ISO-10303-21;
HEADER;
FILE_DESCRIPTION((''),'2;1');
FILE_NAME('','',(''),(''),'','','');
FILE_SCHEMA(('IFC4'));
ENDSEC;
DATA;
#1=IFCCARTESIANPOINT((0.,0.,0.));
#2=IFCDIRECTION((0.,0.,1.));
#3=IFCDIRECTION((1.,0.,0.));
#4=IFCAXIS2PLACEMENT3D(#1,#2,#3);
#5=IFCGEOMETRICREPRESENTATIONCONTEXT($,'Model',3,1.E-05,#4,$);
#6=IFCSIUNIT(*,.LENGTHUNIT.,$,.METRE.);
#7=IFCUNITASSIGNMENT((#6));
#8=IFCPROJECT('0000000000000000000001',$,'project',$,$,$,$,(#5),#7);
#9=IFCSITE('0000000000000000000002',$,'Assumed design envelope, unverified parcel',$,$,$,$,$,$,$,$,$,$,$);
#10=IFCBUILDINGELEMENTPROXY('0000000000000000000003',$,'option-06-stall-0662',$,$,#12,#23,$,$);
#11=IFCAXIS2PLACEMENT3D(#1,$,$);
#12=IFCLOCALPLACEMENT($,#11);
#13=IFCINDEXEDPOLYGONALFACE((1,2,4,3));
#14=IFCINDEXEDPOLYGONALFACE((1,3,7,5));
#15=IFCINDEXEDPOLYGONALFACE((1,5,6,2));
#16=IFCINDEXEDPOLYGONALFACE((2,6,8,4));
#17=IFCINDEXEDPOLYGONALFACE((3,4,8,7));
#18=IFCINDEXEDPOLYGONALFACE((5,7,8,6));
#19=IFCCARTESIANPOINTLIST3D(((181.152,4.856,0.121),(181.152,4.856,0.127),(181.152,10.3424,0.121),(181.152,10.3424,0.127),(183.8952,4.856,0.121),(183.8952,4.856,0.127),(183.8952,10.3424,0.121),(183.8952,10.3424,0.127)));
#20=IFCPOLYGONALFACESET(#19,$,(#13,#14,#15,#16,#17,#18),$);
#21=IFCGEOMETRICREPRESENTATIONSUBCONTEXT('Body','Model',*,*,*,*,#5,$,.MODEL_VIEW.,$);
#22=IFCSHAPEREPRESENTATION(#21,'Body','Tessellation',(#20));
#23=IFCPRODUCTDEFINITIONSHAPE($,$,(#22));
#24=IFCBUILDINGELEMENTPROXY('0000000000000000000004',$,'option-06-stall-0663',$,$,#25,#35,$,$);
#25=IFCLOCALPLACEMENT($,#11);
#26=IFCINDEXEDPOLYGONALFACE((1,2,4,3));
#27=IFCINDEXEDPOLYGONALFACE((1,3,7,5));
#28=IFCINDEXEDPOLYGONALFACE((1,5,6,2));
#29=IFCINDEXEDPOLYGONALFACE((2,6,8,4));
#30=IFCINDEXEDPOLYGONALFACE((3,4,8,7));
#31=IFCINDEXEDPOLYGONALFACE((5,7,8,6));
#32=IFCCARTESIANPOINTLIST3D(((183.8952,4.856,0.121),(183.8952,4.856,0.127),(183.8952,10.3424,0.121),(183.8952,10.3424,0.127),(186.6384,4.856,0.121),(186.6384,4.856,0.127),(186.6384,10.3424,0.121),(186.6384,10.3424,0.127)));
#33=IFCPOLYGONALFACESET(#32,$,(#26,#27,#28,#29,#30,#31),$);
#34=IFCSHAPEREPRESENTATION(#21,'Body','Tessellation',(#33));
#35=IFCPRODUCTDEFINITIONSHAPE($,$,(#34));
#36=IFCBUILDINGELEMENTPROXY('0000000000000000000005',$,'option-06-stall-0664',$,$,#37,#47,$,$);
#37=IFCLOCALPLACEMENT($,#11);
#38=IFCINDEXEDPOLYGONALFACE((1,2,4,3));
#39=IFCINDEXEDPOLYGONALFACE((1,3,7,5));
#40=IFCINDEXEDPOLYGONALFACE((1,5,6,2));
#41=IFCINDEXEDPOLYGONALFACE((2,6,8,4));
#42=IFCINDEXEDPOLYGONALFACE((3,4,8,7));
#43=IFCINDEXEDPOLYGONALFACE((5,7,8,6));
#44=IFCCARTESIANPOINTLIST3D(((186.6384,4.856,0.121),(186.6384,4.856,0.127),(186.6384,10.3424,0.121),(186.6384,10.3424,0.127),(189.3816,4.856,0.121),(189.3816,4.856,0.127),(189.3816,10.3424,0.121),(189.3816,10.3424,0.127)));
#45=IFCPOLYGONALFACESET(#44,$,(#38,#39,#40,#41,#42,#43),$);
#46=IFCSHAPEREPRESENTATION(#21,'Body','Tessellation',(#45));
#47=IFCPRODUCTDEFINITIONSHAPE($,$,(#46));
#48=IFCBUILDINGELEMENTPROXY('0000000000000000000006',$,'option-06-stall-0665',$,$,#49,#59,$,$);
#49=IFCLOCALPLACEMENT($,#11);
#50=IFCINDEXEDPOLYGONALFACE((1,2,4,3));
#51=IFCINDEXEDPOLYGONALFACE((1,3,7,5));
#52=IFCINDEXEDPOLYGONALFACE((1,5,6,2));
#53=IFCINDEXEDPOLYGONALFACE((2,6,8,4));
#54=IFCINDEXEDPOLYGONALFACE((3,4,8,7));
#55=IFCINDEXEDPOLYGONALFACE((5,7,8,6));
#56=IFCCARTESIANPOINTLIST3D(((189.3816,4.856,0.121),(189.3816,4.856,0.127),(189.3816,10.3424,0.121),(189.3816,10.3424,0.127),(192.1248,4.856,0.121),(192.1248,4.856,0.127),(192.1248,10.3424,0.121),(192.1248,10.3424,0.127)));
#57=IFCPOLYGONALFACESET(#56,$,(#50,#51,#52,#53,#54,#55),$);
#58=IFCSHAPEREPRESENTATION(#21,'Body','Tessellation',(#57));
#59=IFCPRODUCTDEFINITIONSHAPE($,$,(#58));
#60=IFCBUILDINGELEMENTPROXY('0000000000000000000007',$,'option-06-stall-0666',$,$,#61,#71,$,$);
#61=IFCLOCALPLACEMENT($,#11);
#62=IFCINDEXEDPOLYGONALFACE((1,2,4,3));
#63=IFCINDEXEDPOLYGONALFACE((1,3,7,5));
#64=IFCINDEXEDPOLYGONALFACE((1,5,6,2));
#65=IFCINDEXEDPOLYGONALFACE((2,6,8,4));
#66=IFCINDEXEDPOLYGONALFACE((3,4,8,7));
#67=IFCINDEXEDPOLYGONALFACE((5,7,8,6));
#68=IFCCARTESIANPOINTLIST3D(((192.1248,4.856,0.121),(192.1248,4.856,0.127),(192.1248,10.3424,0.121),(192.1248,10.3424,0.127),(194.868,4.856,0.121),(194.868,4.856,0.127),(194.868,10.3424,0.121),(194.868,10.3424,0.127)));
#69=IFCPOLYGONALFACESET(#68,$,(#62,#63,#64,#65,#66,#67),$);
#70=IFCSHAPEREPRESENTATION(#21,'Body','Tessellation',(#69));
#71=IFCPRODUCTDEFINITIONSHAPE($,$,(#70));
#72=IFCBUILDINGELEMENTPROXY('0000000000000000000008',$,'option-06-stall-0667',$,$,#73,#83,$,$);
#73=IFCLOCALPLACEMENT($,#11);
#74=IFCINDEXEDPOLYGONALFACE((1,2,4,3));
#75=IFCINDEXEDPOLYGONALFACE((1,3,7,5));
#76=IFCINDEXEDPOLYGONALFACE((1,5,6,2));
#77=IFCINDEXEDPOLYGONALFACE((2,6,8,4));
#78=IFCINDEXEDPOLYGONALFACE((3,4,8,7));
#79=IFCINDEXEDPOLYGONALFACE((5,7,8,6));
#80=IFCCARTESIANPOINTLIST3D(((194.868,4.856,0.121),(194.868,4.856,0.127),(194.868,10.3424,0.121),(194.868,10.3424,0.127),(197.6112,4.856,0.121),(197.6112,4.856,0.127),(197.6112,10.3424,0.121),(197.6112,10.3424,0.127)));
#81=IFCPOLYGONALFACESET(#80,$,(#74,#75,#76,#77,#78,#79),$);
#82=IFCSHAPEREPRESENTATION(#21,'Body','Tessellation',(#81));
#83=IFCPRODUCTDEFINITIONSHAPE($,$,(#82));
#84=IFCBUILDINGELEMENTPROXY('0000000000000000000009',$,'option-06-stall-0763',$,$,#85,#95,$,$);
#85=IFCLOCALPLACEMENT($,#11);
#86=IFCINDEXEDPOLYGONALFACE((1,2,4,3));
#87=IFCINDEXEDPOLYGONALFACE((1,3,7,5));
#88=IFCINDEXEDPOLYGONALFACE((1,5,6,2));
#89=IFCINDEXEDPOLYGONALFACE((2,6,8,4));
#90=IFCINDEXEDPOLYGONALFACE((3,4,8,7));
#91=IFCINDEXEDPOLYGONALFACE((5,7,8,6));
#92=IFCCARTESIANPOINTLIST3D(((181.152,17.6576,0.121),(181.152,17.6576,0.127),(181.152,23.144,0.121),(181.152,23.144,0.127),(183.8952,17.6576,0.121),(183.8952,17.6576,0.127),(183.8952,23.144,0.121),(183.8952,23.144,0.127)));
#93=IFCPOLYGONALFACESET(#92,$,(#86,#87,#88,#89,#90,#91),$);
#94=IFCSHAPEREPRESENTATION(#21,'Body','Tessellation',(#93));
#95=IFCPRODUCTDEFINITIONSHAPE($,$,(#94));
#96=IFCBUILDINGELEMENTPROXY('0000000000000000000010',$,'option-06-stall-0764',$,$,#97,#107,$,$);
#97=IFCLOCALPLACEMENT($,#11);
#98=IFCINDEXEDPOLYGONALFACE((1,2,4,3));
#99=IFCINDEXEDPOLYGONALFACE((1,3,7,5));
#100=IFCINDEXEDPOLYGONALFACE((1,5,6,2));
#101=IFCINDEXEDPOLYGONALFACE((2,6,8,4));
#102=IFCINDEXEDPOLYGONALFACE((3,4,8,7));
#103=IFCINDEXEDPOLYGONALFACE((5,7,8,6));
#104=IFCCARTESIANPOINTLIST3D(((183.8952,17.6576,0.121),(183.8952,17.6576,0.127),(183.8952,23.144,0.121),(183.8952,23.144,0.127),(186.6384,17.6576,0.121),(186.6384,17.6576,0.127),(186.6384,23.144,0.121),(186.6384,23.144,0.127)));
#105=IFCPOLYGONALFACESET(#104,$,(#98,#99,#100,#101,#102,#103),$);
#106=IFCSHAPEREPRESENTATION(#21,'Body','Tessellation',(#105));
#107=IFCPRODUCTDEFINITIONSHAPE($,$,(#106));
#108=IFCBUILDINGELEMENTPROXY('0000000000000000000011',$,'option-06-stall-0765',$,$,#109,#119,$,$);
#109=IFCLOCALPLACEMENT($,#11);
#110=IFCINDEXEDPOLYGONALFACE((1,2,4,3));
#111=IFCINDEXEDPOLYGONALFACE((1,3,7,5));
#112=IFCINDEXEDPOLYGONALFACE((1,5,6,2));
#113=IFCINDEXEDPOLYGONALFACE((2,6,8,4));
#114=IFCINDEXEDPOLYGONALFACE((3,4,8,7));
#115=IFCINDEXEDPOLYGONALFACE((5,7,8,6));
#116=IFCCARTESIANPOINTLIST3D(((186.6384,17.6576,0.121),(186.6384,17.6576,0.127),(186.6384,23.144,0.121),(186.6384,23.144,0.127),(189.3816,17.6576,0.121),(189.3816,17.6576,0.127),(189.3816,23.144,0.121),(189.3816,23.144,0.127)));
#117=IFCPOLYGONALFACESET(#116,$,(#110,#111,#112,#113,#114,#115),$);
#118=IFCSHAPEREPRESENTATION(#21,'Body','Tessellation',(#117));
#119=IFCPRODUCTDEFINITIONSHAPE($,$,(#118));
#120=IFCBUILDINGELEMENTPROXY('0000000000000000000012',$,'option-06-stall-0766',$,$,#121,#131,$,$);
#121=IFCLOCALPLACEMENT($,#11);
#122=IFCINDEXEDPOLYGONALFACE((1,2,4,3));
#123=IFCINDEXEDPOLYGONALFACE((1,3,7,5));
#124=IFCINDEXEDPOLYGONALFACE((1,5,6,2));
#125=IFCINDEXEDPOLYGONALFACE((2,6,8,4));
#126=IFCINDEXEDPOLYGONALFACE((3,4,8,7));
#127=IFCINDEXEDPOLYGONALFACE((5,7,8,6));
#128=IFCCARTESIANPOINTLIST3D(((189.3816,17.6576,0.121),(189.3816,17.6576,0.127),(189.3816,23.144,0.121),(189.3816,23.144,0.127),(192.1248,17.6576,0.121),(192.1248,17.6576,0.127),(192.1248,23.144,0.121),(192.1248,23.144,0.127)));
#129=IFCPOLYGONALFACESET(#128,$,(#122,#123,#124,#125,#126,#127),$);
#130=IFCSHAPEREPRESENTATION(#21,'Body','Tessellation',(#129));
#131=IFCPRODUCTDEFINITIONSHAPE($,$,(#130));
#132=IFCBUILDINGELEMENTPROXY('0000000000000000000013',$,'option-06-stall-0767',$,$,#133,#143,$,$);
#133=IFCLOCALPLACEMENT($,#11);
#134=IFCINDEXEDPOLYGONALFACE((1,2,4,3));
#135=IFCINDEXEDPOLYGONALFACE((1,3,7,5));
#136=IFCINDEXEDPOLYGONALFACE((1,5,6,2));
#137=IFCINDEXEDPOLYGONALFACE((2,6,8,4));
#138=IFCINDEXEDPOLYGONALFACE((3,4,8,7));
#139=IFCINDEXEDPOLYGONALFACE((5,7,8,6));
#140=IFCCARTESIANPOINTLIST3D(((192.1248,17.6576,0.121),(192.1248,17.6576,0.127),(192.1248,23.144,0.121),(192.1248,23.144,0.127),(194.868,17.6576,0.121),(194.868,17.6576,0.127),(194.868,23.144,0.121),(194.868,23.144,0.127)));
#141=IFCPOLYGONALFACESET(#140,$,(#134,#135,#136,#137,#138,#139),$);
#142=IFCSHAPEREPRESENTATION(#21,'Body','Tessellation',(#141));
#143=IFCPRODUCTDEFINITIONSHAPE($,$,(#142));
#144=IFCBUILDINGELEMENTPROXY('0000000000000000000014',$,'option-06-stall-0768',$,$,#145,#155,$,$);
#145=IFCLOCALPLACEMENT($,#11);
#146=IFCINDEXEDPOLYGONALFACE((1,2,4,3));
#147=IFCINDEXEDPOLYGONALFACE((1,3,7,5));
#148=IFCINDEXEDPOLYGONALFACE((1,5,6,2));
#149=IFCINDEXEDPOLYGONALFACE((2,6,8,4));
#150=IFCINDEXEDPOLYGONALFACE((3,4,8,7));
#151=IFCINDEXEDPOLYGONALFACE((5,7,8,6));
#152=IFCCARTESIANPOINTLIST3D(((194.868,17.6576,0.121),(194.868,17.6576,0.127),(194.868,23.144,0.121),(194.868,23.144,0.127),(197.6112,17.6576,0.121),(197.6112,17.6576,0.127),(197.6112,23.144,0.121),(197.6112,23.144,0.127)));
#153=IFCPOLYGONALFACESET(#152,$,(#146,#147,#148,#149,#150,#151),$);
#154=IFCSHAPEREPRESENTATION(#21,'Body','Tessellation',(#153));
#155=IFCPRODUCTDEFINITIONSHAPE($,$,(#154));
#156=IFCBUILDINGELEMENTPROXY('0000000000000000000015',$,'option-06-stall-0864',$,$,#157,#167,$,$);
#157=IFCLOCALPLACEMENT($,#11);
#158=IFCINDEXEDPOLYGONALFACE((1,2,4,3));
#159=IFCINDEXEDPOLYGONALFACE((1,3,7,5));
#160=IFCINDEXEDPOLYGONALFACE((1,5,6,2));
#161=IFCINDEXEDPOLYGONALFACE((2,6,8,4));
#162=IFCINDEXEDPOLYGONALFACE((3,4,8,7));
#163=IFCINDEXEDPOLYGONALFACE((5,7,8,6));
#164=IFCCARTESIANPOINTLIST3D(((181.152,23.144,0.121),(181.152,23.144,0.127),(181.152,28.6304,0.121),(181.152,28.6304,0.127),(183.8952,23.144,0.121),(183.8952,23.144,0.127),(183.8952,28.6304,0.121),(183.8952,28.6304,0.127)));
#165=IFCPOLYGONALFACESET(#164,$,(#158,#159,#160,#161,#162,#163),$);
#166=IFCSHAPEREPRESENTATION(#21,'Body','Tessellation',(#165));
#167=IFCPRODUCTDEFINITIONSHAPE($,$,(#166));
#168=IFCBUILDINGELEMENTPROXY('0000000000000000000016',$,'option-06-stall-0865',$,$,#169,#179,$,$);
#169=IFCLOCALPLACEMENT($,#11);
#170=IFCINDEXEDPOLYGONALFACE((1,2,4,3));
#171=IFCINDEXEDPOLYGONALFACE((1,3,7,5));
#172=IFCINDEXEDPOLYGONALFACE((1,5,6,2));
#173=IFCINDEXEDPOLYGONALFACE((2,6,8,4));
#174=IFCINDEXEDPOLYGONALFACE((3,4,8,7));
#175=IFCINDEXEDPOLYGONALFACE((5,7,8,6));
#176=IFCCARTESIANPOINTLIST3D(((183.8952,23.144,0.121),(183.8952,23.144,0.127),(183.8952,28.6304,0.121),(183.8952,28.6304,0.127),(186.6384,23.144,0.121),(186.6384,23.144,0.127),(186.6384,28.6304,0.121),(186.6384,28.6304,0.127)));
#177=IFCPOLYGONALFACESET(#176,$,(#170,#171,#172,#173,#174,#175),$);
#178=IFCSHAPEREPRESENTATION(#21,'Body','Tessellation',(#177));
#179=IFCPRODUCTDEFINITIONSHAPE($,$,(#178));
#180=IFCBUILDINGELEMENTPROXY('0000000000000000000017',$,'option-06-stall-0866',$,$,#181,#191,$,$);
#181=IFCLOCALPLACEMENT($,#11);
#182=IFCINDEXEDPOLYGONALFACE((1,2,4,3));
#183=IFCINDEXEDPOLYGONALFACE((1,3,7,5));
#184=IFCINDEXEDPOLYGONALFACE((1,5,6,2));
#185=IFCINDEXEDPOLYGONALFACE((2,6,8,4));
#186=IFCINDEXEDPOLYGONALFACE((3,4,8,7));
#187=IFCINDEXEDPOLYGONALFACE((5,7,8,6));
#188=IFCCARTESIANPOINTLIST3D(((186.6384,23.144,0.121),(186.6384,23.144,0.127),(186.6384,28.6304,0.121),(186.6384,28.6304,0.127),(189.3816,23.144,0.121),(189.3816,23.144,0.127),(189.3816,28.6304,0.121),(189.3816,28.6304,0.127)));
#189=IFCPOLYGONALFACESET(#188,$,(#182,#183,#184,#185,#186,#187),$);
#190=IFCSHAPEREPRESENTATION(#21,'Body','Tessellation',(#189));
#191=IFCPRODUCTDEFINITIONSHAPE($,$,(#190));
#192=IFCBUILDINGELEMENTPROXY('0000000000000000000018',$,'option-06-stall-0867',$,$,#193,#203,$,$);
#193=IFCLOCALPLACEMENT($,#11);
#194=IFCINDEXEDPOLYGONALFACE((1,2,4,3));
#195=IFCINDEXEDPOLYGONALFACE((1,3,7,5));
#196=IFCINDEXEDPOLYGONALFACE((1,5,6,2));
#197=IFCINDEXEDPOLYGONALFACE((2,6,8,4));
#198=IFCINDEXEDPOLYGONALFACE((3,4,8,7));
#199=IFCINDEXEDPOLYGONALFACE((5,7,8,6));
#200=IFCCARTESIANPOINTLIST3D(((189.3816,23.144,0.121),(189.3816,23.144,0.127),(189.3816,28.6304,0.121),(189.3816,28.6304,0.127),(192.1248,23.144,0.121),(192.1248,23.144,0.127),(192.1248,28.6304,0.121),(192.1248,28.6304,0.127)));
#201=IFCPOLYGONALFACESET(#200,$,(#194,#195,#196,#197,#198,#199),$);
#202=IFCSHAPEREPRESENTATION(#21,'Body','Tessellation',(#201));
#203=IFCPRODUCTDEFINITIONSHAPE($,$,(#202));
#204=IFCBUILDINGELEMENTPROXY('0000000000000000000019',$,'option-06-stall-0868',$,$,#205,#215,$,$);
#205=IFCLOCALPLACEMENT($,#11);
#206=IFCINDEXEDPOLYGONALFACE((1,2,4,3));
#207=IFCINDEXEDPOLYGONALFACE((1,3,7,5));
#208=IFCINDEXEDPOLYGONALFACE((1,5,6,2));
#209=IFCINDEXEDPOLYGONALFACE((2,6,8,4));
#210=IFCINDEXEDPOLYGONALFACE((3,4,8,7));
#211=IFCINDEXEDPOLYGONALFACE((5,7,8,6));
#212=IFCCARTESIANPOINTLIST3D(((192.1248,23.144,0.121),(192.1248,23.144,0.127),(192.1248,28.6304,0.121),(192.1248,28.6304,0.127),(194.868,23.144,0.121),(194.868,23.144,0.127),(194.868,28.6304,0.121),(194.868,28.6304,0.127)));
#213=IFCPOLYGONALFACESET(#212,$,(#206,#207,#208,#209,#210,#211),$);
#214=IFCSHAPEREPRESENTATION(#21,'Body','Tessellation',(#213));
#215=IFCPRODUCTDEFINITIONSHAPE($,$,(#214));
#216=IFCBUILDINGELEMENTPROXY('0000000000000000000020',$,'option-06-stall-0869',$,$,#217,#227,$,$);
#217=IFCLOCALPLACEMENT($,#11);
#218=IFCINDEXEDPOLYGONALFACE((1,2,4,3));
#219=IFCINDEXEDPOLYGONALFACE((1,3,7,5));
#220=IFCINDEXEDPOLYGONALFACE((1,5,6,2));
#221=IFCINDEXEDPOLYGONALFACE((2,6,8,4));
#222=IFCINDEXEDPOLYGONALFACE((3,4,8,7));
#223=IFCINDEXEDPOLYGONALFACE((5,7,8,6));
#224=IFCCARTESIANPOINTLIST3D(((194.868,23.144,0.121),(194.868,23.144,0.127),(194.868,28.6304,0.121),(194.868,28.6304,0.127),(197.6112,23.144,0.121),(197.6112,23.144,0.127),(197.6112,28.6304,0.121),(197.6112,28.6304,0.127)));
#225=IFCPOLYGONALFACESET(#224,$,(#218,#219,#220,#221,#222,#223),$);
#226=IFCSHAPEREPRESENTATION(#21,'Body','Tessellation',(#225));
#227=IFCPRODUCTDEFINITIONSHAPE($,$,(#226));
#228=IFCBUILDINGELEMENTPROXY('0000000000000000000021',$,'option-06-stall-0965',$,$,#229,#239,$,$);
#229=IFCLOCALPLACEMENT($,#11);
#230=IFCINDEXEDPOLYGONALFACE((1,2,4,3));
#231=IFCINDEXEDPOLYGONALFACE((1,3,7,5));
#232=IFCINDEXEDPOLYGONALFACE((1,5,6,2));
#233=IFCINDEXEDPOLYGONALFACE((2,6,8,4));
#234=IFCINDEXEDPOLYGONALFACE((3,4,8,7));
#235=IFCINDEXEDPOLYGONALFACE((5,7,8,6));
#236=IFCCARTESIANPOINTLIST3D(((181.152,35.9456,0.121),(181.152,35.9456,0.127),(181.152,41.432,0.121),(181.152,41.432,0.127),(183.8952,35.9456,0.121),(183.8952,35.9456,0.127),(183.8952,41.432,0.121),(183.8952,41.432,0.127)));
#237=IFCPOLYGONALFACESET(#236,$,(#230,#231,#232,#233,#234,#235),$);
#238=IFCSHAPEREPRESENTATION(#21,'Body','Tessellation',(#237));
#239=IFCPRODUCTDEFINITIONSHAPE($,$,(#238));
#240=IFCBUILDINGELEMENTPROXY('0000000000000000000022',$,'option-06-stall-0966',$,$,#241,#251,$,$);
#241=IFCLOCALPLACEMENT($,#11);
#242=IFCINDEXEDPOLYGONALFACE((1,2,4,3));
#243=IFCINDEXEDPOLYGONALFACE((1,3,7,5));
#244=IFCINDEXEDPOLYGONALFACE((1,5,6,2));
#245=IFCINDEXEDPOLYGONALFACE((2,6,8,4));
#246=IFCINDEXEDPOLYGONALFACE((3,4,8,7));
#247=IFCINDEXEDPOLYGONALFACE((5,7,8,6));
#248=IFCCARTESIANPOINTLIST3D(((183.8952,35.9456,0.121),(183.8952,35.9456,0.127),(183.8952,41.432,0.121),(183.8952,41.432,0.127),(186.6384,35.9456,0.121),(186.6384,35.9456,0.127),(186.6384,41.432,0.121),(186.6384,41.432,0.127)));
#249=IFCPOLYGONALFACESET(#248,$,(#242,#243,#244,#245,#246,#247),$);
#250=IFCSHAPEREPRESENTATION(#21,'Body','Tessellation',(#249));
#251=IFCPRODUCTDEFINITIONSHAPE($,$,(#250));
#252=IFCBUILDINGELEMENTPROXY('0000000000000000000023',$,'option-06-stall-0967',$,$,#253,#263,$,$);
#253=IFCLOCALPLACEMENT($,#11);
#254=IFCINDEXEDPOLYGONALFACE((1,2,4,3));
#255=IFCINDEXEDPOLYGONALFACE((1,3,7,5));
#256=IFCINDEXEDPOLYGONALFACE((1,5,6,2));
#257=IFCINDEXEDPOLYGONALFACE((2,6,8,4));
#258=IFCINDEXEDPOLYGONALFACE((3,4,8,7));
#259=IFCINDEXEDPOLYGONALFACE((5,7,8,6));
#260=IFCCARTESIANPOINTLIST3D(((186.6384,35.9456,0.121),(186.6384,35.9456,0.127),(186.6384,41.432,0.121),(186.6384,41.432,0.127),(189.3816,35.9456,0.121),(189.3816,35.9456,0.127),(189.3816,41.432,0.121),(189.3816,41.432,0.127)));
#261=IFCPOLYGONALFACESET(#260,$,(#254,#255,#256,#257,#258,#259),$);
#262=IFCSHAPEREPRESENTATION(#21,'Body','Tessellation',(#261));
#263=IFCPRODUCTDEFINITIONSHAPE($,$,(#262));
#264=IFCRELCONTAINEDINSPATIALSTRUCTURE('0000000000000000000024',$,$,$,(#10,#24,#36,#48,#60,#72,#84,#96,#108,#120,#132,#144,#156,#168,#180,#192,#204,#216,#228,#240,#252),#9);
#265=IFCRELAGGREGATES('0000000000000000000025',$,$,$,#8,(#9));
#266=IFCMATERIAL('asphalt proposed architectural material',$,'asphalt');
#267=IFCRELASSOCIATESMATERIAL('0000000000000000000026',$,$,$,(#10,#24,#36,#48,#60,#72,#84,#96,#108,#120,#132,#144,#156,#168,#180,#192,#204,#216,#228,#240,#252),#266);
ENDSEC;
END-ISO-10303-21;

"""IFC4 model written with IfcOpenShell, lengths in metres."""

from ifc_helpers import new_model, si_unit, frame, origin_with_axes, place, context, subcontext, project, spatial, rectangle, extrude, material, element, save


model = new_model("IFC4")

# Units and contexts
model_context = context("Model", 3, precision=1e-05, world=origin_with_axes())
body_context = subcontext(model_context, "Body", "Model", "MODEL_VIEW")
ifc_project = project(units=[si_unit("LENGTHUNIT", "METRE")], contexts=[model_context])

# Site
site = spatial("IfcSite", under=ifc_project, Name="Assumed design envelope, unverified parcel")

# Building element proxies
ifc_material = material(Name="asphalt proposed architectural material", Category="asphalt")
for number, where, z_axis, x_axis, name in (
    (1, (182.5236, 7.5992, 0.121), (0.0, 0.0, 1.0), (1.0, 0.0, 0.0), "option-06-stall-0662"),
    (2, (185.2668, 7.5992, 0.121), (0.0, 0.0, 1.0), (1.0, 0.0, 0.0), "option-06-stall-0663"),
    (3, (188.01, 7.5992, 0.121), (0.0, 0.0, 1.0), (1.0, 0.0, 0.0), "option-06-stall-0664"),
    (4, (190.7532, 7.5992, 0.121), (0.0, 0.0, 1.0), (1.0, 0.0, 0.0), "option-06-stall-0665"),
    (5, (193.4964, 7.5992, 0.121), (0.0, 0.0, 1.0), (1.0, 0.0, 0.0), "option-06-stall-0666"),
    (6, (196.2396, 7.5992, 0.121), (0.0, 0.0, 1.0), (1.0, 0.0, 0.0), "option-06-stall-0667"),
):
    element("IfcBuildingElementProxy", number, at=place(None, frame(where, z_axis=z_axis, x_axis=x_axis)), inside=site, material=ifc_material, Name=name, context=body_context, shape_type="SweptSolid", body=[
        extrude(rectangle(XDim=2.7432, YDim=5.4864), origin_with_axes(), (0.0, 0.0, 1.0), 0.006),
    ])
for number, where, z_axis, x_axis, name in (
    (7, (182.5236, 20.4008, 0.121), (0.0, 0.0, 1.0), (1.0, 0.0, 0.0), "option-06-stall-0763"),
    (8, (185.2668, 20.4008, 0.121), (0.0, 0.0, 1.0), (1.0, 0.0, 0.0), "option-06-stall-0764"),
    (9, (188.01, 20.4008, 0.121), (0.0, 0.0, 1.0), (1.0, 0.0, 0.0), "option-06-stall-0765"),
    (10, (190.7532, 20.4008, 0.121), (0.0, 0.0, 1.0), (1.0, 0.0, 0.0), "option-06-stall-0766"),
    (11, (193.4964, 20.4008, 0.121), (0.0, 0.0, 1.0), (1.0, 0.0, 0.0), "option-06-stall-0767"),
    (12, (196.2396, 20.4008, 0.121), (0.0, 0.0, 1.0), (1.0, 0.0, 0.0), "option-06-stall-0768"),
    (13, (182.5236, 25.8872, 0.121), (0.0, 0.0, 1.0), (1.0, 0.0, 0.0), "option-06-stall-0864"),
    (14, (185.2668, 25.8872, 0.121), (0.0, 0.0, 1.0), (1.0, 0.0, 0.0), "option-06-stall-0865"),
    (15, (188.01, 25.8872, 0.121), (0.0, 0.0, 1.0), (1.0, 0.0, 0.0), "option-06-stall-0866"),
    (16, (190.7532, 25.8872, 0.121), (0.0, 0.0, 1.0), (1.0, 0.0, 0.0), "option-06-stall-0867"),
    (17, (193.4964, 25.8872, 0.121), (0.0, 0.0, 1.0), (1.0, 0.0, 0.0), "option-06-stall-0868"),
    (18, (196.2396, 25.8872, 0.121), (0.0, 0.0, 1.0), (1.0, 0.0, 0.0), "option-06-stall-0869"),
):
    element("IfcBuildingElementProxy", number, at=place(None, frame(where, z_axis=z_axis, x_axis=x_axis)), inside=site, material=ifc_material, Name=name, context=body_context, shape_type="SweptSolid", body=[
        extrude(rectangle(XDim=2.7432, YDim=5.4864), origin_with_axes(), (0.0, 0.0, 1.0), 0.006),
    ])
for number, where, z_axis, x_axis, name in (
    (19, (182.5236, 38.6888, 0.121), (0.0, 0.0, 1.0), (1.0, 0.0, 0.0), "option-06-stall-0965"),
    (20, (185.2668, 38.6888, 0.121), (0.0, 0.0, 1.0), (1.0, 0.0, 0.0), "option-06-stall-0966"),
    (21, (188.01, 38.6888, 0.121), (0.0, 0.0, 1.0), (1.0, 0.0, 0.0), "option-06-stall-0967"),
):
    element("IfcBuildingElementProxy", number, at=place(None, frame(where, z_axis=z_axis, x_axis=x_axis)), inside=site, material=ifc_material, Name=name, context=body_context, shape_type="SweptSolid", body=[
        extrude(rectangle(XDim=2.7432, YDim=5.4864), origin_with_axes(), (0.0, 0.0, 1.0), 0.006),
    ])

save(model, "model.ifc")
